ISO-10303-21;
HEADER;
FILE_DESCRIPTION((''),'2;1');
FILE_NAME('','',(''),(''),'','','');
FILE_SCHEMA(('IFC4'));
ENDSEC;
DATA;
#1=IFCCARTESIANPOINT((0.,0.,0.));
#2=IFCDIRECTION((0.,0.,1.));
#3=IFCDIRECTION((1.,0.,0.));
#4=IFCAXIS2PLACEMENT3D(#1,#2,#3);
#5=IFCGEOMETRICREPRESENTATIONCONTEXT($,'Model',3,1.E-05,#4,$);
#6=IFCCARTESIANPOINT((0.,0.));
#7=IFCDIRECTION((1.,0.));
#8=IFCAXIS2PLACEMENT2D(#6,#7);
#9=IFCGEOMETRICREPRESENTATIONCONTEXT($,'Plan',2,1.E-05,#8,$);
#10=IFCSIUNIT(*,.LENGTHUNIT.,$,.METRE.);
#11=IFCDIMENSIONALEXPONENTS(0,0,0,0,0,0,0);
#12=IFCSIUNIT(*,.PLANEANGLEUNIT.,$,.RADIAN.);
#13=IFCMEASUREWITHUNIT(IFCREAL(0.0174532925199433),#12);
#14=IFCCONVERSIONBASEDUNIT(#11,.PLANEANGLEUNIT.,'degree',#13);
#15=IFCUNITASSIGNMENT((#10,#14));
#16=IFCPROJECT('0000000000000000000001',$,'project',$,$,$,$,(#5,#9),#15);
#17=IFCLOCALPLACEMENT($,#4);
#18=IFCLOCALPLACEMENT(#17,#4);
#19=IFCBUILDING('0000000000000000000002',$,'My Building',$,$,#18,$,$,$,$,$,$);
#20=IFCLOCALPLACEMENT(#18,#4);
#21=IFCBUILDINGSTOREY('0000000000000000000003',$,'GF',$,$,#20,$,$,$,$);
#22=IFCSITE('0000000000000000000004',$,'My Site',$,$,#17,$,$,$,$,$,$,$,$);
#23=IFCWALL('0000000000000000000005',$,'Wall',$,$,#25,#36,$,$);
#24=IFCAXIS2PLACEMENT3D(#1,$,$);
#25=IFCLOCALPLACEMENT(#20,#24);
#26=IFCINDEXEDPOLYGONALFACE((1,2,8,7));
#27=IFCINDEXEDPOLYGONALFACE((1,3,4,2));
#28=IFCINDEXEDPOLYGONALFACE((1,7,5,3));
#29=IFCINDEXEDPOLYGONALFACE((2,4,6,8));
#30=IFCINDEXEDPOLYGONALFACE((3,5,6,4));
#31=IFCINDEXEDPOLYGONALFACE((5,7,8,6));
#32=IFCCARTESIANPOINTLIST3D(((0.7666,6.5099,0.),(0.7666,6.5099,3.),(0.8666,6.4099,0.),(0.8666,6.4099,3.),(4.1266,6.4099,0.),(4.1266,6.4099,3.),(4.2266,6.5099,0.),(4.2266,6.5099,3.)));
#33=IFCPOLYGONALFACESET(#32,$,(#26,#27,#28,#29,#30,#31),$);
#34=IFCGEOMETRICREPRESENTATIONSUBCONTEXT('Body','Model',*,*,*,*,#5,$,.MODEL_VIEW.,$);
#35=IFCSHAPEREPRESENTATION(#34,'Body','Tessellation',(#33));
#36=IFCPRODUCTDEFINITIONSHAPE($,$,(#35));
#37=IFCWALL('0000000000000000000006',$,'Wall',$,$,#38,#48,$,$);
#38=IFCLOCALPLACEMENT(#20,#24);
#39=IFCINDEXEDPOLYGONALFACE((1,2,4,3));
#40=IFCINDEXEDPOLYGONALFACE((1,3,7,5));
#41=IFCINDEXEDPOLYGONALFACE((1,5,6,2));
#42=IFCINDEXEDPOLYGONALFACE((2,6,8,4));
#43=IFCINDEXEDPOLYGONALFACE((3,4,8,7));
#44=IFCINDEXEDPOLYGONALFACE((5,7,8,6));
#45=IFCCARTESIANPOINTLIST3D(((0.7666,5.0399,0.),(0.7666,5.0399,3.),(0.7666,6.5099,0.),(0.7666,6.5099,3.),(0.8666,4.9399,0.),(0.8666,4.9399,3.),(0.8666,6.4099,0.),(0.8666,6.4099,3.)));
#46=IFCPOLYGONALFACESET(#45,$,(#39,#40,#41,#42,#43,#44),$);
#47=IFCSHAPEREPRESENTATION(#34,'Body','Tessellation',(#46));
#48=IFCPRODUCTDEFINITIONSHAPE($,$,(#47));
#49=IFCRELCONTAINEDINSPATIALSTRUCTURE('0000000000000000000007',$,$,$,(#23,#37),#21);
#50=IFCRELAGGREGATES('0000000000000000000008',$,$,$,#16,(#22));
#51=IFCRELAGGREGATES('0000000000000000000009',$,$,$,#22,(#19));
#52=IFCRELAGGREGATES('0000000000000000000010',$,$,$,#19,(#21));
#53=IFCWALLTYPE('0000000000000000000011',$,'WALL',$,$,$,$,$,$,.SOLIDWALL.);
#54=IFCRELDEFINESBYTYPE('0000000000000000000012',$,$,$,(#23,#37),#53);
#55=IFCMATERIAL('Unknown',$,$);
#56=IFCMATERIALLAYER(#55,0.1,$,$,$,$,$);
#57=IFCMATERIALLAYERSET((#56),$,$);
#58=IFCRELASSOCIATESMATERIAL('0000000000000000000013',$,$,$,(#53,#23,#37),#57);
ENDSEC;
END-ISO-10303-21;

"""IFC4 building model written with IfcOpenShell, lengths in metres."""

from ifc_helpers import new_model, entity, si_unit, converted_unit, frame, origin_with_axes, origin_2d_with_axis, place, context, subcontext, project, spatial, line, indexed_curve, outline, extrude, material, layer, layer_set, layer_usage, type_object, element, save


model = new_model("IFC4")

# Units and contexts
model_context = context("Model", 3, precision=1e-05, world=origin_with_axes())
plan_context = context("Plan", 2, precision=1e-05, world=origin_2d_with_axis())
body_context_1 = subcontext(model_context, "Body", "Model", "MODEL_VIEW")
ifc_project = project(units=[si_unit("LENGTHUNIT", "METRE"), converted_unit("PLANEANGLEUNIT", "degree", entity("IfcReal", 0.0174532925199433), si_unit("PLANEANGLEUNIT", "RADIAN"), dimensions=[0, 0, 0, 0, 0, 0, 0])], contexts=[model_context, plan_context])

# Site, building, storey
site_placement = place(None, origin_with_axes())
site = spatial("IfcSite", under=ifc_project, at=site_placement, Name="My Site")
building_placement = place(site_placement, origin_with_axes())
building = spatial("IfcBuilding", under=site, at=building_placement, Name="My Building")
storey_placement = place(building_placement, origin_with_axes())
storey = spatial("IfcBuildingStorey", under=building, at=storey_placement, Name="GF")

# Walls
ifc_material = material(Name="Unknown")
ifc_layer = layer(ifc_material, 0.1)
ifc_layer_set = layer_set([ifc_layer])
ifc_layer_usage_1 = layer_usage(ifc_layer_set, "AXIS2", "POSITIVE", 0.0)
wall_type = type_object("IfcWallType", Name="WALL", PredefinedType="SOLIDWALL", material=ifc_layer_set)
wall_1_placement = place(storey_placement, frame((4.2266, 6.5099, 0.0), z_axis=(0.0, 0.0, 1.0), x_axis=(-1.0, 0.0, 0.0)))
element("IfcWall", 1, at=wall_1_placement, inside=storey, type_object=wall_type, material=ifc_layer_usage_1, Name="Wall", context=body_context_1, shape_type="SweptSolid", body=[
    extrude(outline(indexed_curve([(0.0, 0.0), (0.1, 0.1), (3.36, 0.1), (3.46, 0.0)], segments=[line(1, 2, 3, 4, 1)])), origin_with_axes(), (0.0, 0.0, 1.0), 3.0),
])
ifc_layer_usage_2 = layer_usage(ifc_layer_set, "AXIS2", "POSITIVE", 0.0)
wall_2_placement = place(storey_placement, frame((0.7666, 6.5099, 0.0), z_axis=(0.0, 0.0, 1.0), x_axis=(0.0, -1.0, 0.0)))
element("IfcWall", 2, at=wall_2_placement, inside=storey, type_object=wall_type, material=ifc_layer_usage_2, Name="Wall", context=body_context_1, shape_type="SweptSolid", body=[
    extrude(outline(indexed_curve([(0.0, 0.0), (0.1, 0.1), (1.57, 0.1), (1.47, 0.0)], segments=[line(1, 2, 3, 4, 1)])), origin_with_axes(), (0.0, 0.0, 1.0), 3.0),
])

save(model, "model.ifc")
